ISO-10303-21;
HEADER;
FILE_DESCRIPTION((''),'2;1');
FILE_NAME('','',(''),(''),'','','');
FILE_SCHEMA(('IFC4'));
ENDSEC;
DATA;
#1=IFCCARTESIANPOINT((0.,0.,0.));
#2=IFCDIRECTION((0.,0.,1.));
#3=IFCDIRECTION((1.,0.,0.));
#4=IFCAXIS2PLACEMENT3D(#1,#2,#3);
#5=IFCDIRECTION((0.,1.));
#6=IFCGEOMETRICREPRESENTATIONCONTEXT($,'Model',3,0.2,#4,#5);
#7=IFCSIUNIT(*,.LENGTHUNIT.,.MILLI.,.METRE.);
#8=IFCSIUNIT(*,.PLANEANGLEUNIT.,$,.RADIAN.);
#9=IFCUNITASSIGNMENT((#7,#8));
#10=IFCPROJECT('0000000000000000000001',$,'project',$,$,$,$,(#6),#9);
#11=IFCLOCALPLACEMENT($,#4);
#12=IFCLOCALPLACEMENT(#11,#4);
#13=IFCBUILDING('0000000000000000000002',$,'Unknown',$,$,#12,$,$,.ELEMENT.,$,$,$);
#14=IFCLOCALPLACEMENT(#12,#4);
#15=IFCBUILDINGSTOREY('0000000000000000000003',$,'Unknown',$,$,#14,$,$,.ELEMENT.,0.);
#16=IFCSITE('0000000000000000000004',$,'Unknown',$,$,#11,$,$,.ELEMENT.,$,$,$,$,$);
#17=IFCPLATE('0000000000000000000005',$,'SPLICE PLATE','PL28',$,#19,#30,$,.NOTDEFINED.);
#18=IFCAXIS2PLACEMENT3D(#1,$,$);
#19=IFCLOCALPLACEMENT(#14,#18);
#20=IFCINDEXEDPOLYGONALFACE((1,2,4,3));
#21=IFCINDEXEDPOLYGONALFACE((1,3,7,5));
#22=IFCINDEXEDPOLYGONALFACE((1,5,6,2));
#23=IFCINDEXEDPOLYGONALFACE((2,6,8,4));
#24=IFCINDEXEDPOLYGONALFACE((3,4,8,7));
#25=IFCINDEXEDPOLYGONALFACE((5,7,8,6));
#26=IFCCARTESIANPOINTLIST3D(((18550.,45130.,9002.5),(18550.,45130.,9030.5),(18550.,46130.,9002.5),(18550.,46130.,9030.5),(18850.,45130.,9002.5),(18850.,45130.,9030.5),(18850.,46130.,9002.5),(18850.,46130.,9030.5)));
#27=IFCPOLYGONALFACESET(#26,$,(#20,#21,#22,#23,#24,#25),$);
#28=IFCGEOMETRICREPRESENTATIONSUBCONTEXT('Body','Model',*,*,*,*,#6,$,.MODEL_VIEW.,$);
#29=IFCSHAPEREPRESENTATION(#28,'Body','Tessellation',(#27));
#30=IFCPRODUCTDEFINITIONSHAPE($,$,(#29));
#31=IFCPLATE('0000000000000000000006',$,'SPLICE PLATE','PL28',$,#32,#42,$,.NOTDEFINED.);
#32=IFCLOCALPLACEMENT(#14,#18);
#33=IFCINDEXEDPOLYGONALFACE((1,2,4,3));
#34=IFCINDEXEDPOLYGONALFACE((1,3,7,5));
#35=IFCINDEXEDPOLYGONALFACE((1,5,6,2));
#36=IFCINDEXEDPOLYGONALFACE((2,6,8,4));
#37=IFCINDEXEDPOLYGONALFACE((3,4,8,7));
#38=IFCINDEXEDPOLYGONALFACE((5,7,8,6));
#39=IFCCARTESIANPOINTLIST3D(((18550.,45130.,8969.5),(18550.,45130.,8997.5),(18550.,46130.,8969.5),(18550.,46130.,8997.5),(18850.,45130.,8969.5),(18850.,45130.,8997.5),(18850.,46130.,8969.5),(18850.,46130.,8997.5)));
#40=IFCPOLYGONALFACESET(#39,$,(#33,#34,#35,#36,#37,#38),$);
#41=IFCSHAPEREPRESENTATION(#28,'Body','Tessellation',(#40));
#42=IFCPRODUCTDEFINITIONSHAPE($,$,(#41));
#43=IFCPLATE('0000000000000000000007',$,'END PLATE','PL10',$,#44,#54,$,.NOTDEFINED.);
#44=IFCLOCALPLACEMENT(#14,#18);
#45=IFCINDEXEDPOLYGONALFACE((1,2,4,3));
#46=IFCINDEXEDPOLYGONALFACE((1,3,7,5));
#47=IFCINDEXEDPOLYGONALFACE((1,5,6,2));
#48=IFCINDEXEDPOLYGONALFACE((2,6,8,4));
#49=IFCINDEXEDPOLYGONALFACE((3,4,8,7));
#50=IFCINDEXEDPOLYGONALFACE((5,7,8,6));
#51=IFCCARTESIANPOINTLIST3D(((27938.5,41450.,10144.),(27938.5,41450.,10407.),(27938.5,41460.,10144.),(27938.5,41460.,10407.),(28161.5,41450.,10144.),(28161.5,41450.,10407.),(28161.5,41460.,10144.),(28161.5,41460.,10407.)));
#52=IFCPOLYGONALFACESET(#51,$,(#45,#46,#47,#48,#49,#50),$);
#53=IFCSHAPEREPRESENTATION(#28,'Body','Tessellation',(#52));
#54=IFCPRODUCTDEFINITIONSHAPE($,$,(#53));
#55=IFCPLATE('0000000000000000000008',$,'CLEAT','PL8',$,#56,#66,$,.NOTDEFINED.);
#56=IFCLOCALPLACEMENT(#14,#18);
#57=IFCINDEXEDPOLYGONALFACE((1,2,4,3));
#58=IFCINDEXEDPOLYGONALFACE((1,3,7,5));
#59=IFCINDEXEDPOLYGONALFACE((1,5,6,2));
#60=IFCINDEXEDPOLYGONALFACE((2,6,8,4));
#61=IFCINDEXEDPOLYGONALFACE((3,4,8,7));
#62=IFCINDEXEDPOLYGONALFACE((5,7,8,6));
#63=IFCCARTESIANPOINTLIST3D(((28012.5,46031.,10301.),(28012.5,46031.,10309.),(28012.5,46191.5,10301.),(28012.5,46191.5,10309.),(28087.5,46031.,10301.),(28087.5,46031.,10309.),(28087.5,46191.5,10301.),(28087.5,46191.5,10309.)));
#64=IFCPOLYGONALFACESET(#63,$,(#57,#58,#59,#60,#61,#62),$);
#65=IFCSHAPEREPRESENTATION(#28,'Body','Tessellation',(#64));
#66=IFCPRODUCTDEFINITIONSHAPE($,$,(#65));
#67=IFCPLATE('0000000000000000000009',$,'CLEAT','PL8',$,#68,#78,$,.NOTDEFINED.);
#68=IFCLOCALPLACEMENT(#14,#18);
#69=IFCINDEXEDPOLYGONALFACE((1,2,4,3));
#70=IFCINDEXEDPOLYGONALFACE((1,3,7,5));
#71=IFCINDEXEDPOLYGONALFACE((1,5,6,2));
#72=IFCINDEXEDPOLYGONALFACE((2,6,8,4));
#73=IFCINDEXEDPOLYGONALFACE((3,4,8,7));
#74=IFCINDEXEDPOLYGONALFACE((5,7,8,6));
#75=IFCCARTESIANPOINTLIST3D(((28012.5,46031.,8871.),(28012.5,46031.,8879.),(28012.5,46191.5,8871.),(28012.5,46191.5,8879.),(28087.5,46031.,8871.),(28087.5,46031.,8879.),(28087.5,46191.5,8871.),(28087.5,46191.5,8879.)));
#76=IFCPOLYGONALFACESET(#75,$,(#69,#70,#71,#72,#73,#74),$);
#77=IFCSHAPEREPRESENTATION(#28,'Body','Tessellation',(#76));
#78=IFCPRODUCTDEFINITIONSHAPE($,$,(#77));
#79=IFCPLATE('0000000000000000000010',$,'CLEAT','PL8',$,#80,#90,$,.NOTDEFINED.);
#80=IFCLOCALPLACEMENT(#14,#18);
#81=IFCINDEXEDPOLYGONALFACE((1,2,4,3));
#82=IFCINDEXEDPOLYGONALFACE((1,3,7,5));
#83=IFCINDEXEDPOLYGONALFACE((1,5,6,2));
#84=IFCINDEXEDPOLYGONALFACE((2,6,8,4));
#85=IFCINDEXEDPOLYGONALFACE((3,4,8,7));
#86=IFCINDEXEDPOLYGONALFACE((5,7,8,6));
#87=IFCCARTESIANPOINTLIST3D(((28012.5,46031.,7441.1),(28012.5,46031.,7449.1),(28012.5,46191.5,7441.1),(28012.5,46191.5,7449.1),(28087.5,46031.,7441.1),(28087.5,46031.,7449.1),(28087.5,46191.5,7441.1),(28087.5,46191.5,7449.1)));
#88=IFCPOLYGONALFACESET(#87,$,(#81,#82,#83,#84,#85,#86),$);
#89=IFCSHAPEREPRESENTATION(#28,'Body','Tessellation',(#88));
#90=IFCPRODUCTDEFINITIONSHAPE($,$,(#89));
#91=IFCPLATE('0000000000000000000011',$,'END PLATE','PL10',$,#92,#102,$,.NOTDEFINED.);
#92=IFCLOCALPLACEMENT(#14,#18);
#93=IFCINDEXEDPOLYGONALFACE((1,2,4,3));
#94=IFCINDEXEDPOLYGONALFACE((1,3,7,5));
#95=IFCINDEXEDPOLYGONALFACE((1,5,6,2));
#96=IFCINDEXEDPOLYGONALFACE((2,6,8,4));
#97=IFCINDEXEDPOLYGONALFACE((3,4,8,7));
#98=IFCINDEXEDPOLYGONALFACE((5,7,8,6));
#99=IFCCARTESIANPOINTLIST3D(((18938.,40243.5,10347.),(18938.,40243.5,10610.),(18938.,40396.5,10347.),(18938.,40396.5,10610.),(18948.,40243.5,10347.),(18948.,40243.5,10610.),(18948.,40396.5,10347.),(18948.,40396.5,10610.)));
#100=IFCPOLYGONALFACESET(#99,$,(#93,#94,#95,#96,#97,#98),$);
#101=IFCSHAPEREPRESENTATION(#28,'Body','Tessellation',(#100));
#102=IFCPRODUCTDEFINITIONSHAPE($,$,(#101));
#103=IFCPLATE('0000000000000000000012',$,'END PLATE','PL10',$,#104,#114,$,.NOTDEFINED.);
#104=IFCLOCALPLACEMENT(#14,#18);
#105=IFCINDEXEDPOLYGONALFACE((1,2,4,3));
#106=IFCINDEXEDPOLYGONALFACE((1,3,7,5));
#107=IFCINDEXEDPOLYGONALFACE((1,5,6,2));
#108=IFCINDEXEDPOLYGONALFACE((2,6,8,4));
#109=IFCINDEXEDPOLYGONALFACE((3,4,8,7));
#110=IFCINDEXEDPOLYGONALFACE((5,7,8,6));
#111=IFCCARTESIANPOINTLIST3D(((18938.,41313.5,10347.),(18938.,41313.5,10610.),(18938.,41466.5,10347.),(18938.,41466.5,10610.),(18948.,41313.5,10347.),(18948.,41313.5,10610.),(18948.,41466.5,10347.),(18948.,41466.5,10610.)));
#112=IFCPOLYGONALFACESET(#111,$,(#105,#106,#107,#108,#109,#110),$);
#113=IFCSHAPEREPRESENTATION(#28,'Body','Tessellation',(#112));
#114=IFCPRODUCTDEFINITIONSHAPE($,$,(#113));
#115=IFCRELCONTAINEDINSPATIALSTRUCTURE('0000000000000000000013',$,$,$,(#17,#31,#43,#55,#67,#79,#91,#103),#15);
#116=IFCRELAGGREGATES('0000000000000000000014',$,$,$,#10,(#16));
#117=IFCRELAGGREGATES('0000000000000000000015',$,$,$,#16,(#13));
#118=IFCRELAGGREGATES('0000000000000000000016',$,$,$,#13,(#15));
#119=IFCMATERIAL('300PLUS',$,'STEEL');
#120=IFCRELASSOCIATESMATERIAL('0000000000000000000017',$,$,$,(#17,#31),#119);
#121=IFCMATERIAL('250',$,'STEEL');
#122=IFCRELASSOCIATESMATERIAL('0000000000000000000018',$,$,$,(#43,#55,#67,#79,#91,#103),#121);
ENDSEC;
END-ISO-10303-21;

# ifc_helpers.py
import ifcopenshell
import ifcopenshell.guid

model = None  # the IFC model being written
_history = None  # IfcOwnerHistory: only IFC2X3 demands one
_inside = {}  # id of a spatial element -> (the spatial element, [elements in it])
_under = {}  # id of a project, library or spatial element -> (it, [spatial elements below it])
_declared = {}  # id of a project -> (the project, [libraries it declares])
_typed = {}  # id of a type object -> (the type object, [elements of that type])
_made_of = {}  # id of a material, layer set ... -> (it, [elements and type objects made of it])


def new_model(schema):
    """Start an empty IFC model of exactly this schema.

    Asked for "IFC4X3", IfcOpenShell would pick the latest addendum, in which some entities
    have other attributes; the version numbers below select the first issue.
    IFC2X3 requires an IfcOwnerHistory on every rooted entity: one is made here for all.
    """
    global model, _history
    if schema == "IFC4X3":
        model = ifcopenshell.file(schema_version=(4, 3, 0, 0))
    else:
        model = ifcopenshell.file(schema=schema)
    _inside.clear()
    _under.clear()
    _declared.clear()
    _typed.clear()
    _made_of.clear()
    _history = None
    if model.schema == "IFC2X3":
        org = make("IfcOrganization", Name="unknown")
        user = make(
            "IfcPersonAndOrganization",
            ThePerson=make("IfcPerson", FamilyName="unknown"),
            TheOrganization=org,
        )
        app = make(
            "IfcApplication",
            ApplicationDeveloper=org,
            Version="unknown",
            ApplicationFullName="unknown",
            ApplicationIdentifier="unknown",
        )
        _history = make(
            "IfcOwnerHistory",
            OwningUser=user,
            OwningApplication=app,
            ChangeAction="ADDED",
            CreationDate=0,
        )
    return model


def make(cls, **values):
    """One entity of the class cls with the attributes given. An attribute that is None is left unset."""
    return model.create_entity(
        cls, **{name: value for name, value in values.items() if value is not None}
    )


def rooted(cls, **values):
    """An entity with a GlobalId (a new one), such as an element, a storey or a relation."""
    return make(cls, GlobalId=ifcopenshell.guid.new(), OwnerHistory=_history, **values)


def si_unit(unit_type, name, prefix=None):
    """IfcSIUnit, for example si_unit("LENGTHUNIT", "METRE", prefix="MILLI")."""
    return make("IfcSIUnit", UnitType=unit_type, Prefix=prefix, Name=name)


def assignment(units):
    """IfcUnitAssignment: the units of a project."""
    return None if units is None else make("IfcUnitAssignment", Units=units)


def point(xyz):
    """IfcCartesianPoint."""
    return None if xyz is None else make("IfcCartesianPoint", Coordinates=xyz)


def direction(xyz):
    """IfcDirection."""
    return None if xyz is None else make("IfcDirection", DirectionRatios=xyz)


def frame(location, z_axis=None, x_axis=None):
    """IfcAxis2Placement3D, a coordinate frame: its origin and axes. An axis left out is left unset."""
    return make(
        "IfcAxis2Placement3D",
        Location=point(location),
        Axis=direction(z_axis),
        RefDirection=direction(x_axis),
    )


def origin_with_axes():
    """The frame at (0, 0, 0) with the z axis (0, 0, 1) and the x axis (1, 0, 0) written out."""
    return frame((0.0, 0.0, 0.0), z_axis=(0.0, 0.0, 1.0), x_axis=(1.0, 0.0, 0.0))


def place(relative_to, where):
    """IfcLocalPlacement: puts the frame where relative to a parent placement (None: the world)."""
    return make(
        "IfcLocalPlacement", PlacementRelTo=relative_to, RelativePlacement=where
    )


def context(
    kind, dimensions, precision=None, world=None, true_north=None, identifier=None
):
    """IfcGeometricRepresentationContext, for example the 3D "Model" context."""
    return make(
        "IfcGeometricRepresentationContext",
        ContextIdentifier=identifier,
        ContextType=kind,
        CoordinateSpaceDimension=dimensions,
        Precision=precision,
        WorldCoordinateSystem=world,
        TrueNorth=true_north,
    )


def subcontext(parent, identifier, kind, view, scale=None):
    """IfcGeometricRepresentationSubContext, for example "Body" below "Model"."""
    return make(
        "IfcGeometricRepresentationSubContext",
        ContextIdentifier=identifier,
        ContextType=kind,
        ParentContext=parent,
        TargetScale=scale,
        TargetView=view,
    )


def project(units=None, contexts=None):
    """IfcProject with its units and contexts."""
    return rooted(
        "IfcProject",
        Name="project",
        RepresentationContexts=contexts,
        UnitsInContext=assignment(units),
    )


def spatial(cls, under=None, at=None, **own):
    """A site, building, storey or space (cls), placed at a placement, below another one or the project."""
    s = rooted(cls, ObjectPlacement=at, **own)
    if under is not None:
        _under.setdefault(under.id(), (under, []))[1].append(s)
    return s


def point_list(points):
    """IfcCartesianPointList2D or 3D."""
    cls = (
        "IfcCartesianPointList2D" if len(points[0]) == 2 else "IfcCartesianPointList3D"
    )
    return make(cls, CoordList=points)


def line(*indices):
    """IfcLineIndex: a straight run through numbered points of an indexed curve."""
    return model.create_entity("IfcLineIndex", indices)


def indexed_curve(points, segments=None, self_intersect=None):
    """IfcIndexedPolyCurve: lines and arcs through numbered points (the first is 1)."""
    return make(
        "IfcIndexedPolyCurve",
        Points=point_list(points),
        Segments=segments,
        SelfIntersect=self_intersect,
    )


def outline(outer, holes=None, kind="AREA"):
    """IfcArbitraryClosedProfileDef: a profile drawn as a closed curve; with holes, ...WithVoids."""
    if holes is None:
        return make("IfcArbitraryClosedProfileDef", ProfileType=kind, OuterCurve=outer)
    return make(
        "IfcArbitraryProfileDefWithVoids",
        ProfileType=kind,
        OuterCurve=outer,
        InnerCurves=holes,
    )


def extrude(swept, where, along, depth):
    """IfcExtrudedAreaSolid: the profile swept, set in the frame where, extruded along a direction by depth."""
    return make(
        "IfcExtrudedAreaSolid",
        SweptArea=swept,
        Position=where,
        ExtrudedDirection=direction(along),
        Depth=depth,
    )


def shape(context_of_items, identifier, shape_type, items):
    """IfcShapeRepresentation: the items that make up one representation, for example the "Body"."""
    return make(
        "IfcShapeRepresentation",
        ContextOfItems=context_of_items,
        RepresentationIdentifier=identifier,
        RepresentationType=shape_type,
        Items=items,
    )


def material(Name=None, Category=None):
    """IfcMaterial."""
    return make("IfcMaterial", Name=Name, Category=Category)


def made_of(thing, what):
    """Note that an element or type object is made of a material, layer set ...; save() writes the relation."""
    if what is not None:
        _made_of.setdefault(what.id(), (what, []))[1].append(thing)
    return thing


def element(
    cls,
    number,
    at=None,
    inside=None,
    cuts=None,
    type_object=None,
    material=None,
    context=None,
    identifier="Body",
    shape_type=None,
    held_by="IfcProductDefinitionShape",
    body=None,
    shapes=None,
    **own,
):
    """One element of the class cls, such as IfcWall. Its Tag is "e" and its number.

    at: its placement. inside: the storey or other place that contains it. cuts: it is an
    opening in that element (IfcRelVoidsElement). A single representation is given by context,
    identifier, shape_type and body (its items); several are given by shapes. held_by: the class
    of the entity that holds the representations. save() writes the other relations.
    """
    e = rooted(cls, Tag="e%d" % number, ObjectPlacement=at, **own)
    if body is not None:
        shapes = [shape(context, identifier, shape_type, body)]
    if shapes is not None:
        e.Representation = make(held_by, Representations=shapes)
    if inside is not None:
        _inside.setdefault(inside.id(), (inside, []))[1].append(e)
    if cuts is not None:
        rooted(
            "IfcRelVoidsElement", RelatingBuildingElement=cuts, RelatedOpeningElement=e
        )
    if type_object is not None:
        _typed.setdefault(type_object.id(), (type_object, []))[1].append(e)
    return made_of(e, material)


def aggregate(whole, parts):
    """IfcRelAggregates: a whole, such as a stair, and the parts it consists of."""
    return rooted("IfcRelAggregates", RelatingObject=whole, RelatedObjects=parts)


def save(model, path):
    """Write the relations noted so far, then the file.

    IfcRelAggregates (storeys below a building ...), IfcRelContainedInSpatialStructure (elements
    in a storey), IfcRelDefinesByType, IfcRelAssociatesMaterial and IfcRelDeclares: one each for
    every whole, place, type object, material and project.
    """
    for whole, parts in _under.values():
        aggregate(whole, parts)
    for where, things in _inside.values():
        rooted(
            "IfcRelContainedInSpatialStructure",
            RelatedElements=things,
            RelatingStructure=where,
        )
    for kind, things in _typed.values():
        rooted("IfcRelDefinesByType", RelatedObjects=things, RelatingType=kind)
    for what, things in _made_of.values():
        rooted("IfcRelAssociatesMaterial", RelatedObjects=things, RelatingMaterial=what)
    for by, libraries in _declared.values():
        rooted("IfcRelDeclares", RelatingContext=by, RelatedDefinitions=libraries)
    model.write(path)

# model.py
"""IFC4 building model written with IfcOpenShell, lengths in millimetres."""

from ifc_helpers import new_model, si_unit, direction, frame, origin_with_axes, place, context, subcontext, project, spatial, line, indexed_curve, outline, extrude, material, element, save


model = new_model("IFC4")

# Units and contexts
model_context = context("Model", 3, precision=0.2, world=origin_with_axes(), true_north=direction((0.0, 1.0)))
body_context = subcontext(model_context, "Body", "Model", "MODEL_VIEW")
ifc_project = project(units=[si_unit("LENGTHUNIT", "METRE", prefix="MILLI"), si_unit("PLANEANGLEUNIT", "RADIAN")], contexts=[model_context])

# Site, building, storey
site_placement = place(None, origin_with_axes())
site = spatial("IfcSite", under=ifc_project, at=site_placement, Name="Unknown", CompositionType="ELEMENT")
building_placement = place(site_placement, origin_with_axes())
building = spatial("IfcBuilding", under=site, at=building_placement, Name="Unknown", CompositionType="ELEMENT")
storey_placement = place(building_placement, origin_with_axes())
storey = spatial("IfcBuildingStorey", under=building, at=storey_placement, Name="Unknown", CompositionType="ELEMENT", Elevation=0.0)

# Shared definitions
ifc_material_1 = material(Name="300PLUS", Category="STEEL")

# Plates
for number, where, z_axis, x_axis, name in (
    (1, (18850.0, 45130.0, 9016.5), (0.0, 0.0, 1.0), (0.0, 1.0, 0.0), "SPLICE PLATE"),
    (2, (18850.0, 45130.0, 8983.5), (0.0, 0.0, 1.0), (0.0, 1.0, 0.0), "SPLICE PLATE"),
):
    element("IfcPlate", number, at=place(storey_placement, frame(where, z_axis=z_axis, x_axis=x_axis)), inside=storey, material=ifc_material_1, Name=name, Description="PL28", PredefinedType="NOTDEFINED", context=body_context, shape_type="SolidModel", body=[
        extrude(outline(indexed_curve([(0.0, 0.0), (1000.0, 0.0), (1000.0, 300.0), (0.0, 300.0)], segments=[line(1, 2, 3, 4, 1)])), frame((0.0, 0.0, 14.0), z_axis=(0.0, 0.0, 1.0), x_axis=(1.0, 0.0, 0.0)), (0.0, 0.0, -1.0), 28.0),
    ])
ifc_material_2 = material(Name="250", Category="STEEL")
plate_1_placement = place(storey_placement, frame((27938.5, 41455.0, 10144.0), z_axis=(0.0, -1.0, 0.0), x_axis=(1.0, 0.0, 0.0)))
element("IfcPlate", 3, at=plate_1_placement, inside=storey, material=ifc_material_2, Name="END PLATE", Description="PL10", PredefinedType="NOTDEFINED", context=body_context, shape_type="SolidModel", body=[
    extrude(outline(indexed_curve([(0.0, 0.0), (223.0, 0.0), (223.0, 263.0), (0.0, 263.0)], segments=[line(1, 2, 3, 4, 1)])), frame((0.0, 0.0, 5.0), z_axis=(0.0, 0.0, 1.0), x_axis=(1.0, 0.0, 0.0)), (0.0, 0.0, -1.0), 10.0),
])
for number, where, z_axis, x_axis, name in (
    (4, (28012.5, 46031.0, 10305.0), (0.0, 0.0, 1.0), (1.0, 0.0, 0.0), "CLEAT"),
    (5, (28012.5, 46031.0, 8875.0), (0.0, 0.0, 1.0), (1.0, 0.0, 0.0), "CLEAT"),
    (6, (28012.5, 46031.0, 7445.1), (0.0, 0.0, 1.0), (1.0, 0.0, 0.0), "CLEAT"),
):
    element("IfcPlate", number, at=place(storey_placement, frame(where, z_axis=z_axis, x_axis=x_axis)), inside=storey, material=ifc_material_2, Name=name, Description="PL8", PredefinedType="NOTDEFINED", context=body_context, shape_type="SolidModel", body=[
        extrude(outline(indexed_curve([(0.0, 0.0), (75.0, 0.0), (75.0, 160.5), (0.0, 160.5)], segments=[line(1, 2, 3, 4, 1)])), frame((0.0, 0.0, 4.0), z_axis=(0.0, 0.0, 1.0), x_axis=(1.0, 0.0, 0.0)), (0.0, 0.0, -1.0), 8.0),
    ])
for number, where, z_axis, x_axis, name in (
    (7, (18943.0, 40396.5, 10347.0), (-1.0, 0.0, 0.0), (0.0, -1.0, 0.0), "END PLATE"),
    (8, (18943.0, 41466.5, 10347.0), (-1.0, 0.0, 0.0), (0.0, -1.0, 0.0), "END PLATE"),
):
    element("IfcPlate", number, at=place(storey_placement, frame(where, z_axis=z_axis, x_axis=x_axis)), inside=storey, material=ifc_material_2, Name=name, Description="PL10", PredefinedType="NOTDEFINED", context=body_context, shape_type="SolidModel", body=[
        extrude(outline(indexed_curve([(0.0, 0.0), (153.0, 0.0), (153.0, 263.0), (0.0, 263.0)], segments=[line(1, 2, 3, 4, 1)])), frame((0.0, 0.0, 5.0), z_axis=(0.0, 0.0, 1.0), x_axis=(1.0, 0.0, 0.0)), (0.0, 0.0, -1.0), 10.0),
    ])

save(model, "model.ifc")
